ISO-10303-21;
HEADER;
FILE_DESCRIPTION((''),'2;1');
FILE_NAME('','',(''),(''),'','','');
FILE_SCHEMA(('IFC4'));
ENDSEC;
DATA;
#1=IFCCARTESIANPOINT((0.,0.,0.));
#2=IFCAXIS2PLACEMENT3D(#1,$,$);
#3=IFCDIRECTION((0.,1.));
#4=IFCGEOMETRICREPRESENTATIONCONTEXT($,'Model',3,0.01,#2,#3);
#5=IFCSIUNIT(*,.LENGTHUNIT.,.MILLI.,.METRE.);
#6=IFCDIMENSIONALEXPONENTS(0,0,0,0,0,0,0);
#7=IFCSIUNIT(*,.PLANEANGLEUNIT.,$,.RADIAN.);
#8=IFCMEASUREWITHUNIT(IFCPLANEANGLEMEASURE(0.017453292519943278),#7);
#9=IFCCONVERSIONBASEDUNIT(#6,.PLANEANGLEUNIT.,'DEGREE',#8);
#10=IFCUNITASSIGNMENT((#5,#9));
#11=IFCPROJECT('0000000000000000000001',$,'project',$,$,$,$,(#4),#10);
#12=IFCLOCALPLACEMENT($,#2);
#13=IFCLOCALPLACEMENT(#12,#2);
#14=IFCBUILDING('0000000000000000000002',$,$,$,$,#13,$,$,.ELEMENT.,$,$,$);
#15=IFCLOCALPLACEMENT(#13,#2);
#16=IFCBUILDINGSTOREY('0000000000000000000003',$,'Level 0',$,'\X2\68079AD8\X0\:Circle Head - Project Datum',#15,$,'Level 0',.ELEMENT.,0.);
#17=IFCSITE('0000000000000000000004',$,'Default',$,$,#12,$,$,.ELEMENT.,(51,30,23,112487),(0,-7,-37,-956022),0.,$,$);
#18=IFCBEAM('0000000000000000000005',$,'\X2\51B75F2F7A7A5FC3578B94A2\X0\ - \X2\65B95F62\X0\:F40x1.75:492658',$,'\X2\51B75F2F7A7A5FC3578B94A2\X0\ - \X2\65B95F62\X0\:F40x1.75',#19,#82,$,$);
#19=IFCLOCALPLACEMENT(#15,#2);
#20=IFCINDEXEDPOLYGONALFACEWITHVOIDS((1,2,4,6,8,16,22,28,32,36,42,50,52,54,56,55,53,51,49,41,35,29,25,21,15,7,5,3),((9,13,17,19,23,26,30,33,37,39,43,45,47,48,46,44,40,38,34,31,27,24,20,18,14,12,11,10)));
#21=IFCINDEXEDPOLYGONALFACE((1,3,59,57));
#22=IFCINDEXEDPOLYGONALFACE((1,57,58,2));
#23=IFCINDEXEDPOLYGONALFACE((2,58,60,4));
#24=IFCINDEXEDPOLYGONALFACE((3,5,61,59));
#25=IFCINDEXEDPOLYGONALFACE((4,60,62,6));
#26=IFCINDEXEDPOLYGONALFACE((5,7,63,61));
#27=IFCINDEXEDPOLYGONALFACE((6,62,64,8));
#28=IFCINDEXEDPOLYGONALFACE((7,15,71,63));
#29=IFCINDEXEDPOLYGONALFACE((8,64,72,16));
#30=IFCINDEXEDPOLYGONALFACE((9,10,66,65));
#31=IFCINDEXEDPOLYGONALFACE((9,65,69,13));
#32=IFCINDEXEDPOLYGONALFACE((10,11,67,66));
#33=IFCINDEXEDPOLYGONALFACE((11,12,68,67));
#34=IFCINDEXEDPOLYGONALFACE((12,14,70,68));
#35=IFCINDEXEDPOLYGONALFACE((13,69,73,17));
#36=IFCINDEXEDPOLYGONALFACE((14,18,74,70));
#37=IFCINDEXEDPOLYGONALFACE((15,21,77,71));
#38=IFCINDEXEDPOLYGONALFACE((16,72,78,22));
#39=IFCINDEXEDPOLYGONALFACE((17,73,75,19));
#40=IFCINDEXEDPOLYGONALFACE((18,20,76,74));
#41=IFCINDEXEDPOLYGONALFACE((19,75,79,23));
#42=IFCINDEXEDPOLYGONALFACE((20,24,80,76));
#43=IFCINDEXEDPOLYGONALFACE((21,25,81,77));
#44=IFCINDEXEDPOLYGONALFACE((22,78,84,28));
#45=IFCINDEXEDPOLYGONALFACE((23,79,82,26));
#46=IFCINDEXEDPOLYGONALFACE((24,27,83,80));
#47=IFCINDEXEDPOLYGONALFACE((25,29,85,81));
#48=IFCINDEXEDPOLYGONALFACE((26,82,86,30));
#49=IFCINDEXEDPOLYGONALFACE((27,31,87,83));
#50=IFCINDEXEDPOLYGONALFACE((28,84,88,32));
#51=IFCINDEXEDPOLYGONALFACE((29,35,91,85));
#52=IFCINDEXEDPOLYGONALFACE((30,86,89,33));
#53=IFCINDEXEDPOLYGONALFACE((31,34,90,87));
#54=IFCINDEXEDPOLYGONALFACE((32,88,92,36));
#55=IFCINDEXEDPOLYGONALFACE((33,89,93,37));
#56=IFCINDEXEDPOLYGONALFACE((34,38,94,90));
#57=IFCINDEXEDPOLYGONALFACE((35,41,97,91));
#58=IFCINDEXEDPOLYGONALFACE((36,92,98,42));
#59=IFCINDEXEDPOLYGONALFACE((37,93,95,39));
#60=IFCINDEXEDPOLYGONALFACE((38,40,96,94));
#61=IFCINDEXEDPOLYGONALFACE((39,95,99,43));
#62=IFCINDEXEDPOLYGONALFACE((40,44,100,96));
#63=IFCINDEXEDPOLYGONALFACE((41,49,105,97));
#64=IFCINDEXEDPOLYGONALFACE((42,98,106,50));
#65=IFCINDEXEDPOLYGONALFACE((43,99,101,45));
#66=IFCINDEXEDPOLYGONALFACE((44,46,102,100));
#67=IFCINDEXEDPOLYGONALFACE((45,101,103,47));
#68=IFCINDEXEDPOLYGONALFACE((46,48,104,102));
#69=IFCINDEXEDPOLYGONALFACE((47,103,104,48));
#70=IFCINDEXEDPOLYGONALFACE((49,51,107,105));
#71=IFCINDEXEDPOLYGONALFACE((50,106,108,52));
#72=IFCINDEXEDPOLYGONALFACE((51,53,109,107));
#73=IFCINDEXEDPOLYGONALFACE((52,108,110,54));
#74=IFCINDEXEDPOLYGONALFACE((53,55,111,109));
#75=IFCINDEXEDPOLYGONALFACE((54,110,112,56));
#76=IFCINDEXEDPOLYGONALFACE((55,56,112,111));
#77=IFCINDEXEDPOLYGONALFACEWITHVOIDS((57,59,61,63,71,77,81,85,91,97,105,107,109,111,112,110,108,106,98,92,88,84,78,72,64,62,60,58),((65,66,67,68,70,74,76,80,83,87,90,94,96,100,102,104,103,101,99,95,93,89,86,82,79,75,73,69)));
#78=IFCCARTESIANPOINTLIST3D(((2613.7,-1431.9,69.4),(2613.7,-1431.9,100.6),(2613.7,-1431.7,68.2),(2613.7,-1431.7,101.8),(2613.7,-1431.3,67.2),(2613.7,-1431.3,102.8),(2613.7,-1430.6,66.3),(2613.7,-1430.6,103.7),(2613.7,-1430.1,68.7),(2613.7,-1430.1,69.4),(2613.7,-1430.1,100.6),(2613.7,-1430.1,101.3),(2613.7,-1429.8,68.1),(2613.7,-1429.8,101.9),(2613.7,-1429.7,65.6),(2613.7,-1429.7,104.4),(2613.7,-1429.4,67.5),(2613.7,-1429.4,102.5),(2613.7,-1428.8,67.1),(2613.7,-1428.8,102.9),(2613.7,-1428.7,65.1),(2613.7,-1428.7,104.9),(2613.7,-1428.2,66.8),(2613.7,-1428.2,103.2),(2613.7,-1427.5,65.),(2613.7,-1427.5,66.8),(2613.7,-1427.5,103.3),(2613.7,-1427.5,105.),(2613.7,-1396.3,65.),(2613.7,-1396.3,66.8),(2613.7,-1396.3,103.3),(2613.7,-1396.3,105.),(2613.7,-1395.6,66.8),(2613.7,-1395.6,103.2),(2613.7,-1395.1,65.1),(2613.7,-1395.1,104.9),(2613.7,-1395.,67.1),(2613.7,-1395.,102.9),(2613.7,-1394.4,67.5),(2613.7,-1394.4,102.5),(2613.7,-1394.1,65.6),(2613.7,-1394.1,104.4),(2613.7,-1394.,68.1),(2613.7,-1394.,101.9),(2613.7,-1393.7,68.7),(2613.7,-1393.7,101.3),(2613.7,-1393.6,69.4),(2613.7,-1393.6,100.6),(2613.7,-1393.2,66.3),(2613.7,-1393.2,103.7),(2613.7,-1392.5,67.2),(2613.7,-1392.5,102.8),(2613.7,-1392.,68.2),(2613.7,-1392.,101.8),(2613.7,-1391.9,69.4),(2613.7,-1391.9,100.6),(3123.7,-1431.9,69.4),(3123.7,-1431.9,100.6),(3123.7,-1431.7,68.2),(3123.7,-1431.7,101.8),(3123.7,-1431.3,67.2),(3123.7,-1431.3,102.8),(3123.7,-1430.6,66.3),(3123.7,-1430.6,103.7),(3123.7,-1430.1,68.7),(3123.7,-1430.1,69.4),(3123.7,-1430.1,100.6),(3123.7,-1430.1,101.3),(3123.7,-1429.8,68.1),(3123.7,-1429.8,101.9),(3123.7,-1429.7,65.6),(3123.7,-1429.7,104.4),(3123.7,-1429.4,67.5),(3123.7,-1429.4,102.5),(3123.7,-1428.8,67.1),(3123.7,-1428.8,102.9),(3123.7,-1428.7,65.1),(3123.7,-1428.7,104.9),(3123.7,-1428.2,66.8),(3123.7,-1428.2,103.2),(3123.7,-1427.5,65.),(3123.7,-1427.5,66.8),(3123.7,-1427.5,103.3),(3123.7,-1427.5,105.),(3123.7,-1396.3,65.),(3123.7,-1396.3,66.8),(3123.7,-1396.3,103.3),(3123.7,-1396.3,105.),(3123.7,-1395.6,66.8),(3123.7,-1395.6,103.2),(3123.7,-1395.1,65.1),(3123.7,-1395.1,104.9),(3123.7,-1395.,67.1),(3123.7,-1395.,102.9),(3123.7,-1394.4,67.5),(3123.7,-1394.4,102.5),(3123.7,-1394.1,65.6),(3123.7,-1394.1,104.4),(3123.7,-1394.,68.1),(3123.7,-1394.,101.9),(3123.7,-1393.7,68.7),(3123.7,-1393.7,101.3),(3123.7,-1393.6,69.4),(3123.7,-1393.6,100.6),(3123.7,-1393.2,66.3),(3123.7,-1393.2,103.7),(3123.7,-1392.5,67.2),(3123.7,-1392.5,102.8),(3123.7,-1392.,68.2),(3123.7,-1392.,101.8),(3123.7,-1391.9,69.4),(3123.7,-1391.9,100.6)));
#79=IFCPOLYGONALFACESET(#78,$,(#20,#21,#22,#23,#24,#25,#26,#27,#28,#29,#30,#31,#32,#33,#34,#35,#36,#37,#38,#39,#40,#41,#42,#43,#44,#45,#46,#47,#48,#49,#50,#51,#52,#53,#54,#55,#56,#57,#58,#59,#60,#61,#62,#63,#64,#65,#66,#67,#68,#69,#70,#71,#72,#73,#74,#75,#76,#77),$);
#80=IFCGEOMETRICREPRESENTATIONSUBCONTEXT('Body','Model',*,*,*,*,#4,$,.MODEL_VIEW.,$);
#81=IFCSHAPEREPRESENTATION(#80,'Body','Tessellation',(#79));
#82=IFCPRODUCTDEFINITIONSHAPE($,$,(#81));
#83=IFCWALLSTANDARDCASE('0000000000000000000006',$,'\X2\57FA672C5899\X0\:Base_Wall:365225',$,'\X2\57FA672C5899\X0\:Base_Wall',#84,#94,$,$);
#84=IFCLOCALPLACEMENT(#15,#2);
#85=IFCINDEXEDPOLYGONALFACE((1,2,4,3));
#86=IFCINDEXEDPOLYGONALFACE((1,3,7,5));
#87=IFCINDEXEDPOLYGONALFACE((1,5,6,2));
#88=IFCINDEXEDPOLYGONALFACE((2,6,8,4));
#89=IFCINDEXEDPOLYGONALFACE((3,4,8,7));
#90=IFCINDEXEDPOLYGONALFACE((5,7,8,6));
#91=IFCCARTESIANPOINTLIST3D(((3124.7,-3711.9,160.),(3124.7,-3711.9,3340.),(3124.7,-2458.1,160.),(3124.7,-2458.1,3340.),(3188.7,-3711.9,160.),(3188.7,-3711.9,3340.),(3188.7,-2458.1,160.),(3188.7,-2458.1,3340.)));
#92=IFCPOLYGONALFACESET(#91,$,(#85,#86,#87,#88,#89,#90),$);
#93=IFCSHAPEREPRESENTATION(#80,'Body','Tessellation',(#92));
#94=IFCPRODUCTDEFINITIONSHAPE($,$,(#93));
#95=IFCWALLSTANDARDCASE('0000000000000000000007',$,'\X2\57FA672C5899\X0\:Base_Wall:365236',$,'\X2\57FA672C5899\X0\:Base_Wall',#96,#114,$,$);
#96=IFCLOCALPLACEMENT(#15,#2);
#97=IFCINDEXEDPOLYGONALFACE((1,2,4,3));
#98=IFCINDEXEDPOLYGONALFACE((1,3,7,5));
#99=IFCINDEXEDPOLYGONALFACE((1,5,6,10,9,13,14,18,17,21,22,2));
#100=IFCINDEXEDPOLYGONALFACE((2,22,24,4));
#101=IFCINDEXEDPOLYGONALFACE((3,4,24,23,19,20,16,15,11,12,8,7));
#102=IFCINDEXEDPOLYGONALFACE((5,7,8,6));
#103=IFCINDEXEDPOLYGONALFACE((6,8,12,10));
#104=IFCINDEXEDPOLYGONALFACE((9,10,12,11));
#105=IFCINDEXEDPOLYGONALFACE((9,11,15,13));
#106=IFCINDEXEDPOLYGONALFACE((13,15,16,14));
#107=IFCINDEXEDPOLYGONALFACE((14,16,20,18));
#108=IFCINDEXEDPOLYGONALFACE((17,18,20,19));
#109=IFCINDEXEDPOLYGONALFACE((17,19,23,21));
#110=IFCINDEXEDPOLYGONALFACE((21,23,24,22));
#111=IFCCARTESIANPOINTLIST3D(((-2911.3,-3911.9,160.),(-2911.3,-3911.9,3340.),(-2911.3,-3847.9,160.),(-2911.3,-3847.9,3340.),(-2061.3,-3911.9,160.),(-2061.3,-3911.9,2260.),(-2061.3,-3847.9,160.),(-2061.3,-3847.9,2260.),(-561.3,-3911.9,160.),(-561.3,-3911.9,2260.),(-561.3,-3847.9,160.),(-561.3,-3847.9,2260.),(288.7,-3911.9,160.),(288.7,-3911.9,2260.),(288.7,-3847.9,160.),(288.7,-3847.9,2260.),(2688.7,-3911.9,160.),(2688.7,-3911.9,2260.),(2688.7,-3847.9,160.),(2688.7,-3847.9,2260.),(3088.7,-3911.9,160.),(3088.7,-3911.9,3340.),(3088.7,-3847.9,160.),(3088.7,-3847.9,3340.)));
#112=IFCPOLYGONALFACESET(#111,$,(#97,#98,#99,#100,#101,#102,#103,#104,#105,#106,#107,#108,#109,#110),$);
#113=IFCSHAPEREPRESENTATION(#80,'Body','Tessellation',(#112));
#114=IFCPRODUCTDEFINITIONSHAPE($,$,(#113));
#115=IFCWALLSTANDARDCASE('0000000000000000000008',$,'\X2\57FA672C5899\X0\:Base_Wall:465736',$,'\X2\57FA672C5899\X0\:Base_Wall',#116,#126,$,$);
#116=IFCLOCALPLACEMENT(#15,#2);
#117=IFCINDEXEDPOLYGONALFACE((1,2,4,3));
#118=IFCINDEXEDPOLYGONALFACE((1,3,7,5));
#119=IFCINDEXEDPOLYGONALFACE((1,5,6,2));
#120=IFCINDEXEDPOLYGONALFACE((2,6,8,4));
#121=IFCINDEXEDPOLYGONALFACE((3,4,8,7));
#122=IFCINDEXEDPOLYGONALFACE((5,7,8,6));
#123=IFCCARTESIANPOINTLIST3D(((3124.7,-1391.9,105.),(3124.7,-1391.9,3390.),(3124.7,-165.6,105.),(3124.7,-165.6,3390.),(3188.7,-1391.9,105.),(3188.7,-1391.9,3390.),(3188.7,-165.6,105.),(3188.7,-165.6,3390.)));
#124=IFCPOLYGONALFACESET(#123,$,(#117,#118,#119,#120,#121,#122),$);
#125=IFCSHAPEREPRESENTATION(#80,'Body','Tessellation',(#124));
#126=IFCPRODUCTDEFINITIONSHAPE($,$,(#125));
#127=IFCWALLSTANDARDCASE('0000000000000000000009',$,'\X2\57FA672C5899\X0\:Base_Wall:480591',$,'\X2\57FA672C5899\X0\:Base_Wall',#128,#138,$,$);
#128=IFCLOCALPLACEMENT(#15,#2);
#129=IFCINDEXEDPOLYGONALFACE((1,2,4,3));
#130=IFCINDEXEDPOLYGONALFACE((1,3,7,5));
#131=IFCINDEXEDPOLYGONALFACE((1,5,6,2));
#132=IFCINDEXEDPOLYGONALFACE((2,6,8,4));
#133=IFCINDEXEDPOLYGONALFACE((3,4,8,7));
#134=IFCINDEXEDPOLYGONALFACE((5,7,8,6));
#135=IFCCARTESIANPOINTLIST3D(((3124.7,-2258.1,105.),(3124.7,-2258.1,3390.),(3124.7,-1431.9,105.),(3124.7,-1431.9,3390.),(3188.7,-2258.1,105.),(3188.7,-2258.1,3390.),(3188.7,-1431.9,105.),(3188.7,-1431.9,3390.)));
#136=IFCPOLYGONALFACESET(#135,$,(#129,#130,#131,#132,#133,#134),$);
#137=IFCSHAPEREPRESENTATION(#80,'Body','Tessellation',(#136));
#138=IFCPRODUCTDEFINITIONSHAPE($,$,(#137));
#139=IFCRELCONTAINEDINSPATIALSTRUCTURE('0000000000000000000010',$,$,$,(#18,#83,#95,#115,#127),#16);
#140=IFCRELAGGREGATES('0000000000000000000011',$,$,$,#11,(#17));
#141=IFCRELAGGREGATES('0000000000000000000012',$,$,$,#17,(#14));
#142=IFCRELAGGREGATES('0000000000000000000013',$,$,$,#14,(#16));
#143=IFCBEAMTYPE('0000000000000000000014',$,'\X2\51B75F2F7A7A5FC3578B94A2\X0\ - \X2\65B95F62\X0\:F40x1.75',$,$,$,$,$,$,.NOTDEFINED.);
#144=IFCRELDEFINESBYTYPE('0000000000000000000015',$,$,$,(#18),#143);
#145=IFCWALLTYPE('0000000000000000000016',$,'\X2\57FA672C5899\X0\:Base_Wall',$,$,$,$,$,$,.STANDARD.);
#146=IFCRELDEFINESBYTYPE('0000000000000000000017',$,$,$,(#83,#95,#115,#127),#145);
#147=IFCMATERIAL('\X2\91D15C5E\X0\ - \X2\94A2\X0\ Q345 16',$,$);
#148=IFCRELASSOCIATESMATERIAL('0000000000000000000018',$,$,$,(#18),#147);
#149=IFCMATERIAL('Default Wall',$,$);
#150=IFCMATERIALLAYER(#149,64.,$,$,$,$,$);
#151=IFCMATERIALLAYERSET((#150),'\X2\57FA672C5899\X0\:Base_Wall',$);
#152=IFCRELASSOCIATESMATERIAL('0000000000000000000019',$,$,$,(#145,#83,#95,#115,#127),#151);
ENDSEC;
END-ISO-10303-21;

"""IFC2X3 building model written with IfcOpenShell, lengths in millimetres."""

from ifc_helpers import new_model, entity, si_unit, converted_unit, direction, frame, frame_2d, origin, place, context, subcontext, project, spatial, polyline, circle_curve, parameter, trimmed, segment, composite_curve, rectangle, outline, extrude, material, layer, layer_set, layer_usage, type_object, element, save


model = new_model("IFC2X3")

# Units and contexts
model_context = context("Model", 3, precision=0.01, world=origin(), true_north=direction((0.0, 1.0)))
body_context = subcontext(model_context, "Body", "Model", "MODEL_VIEW")
ifc_project = project(units=[si_unit("LENGTHUNIT", "METRE", prefix="MILLI"), converted_unit("PLANEANGLEUNIT", "DEGREE", entity("IfcPlaneAngleMeasure", 0.017453292519943278), si_unit("PLANEANGLEUNIT", "RADIAN"), dimensions=[0, 0, 0, 0, 0, 0, 0])], contexts=[model_context])

# Site, building, storey
site_placement = place(None, origin())
site = spatial("IfcSite", under=ifc_project, at=site_placement, Name="Default", CompositionType="ELEMENT", RefLatitude=(51, 30, 23, 112487), RefLongitude=(0, -7, -37, -956022), RefElevation=0.0)
building_placement = place(site_placement, origin())
building = spatial("IfcBuilding", under=site, at=building_placement, CompositionType="ELEMENT")
storey_placement = place(building_placement, origin())
storey = spatial("IfcBuildingStorey", under=building, at=storey_placement, Name="Level 0", ObjectType="标高:Circle Head - Project Datum", LongName="Level 0", CompositionType="ELEMENT", Elevation=0.0)

# Beam
ifc_material_1 = material(Name="金属 - 钢 Q345 16")
beam_type_1 = type_object("IfcBeamType", Name="冷弯空心型钢 - 方形:F40x1.75", PredefinedType="NOTDEFINED")
beam_1_placement = place(storey_placement, frame((2613.7, -1411.9, 105.0)))
element("IfcBeam", 1, at=beam_1_placement, inside=storey, type_object=beam_type_1, material=ifc_material_1, Name="冷弯空心型钢 - 方形:F40x1.75:492658", ObjectType="冷弯空心型钢 - 方形:F40x1.75", context=body_context, shape_type="SweptSolid", body=[
    extrude(outline(composite_curve([segment(trimmed(circle_curve(frame_2d((-15.6, 15.6), x_axis=(1.0, 0.0)), 4.4), [parameter(90.0)], [parameter(180.0)], True, "PARAMETER"), True, "CONTINUOUS"), segment(polyline([(-20.0, 15.6), (-20.0, -15.6)]), True, "CONTINUOUS"), segment(trimmed(circle_curve(frame_2d((-15.6, -15.6), x_axis=(1.0, 0.0)), 4.4), [parameter(180.0)], [parameter(270.0)], True, "PARAMETER"), True, "CONTINUOUS"), segment(polyline([(-15.6, -20.0), (15.6, -20.0)]), True, "CONTINUOUS"), segment(trimmed(circle_curve(frame_2d((15.6, -15.6), x_axis=(1.0, 0.0)), 4.4), [parameter(270.0)], [parameter(0.0)], True, "PARAMETER"), True, "CONTINUOUS"), segment(polyline([(20.0, -15.6), (20.0, 15.6)]), True, "CONTINUOUS"), segment(trimmed(circle_curve(frame_2d((15.6, 15.6), x_axis=(1.0, 0.0)), 4.4), [parameter(0.0)], [parameter(90.0)], True, "PARAMETER"), True, "CONTINUOUS"), segment(polyline([(15.6, 20.0), (-15.6, 20.0)]), True, "CONTINUOUS")], self_intersect=False), holes=[composite_curve([segment(polyline([(-15.6, 18.3), (15.6, 18.3)]), True, "CONTINUOUS"), segment(trimmed(circle_curve(frame_2d((15.6, 15.6), x_axis=(1.0, 0.0)), 2.6), [parameter(0.0)], [parameter(90.0)], True, "PARAMETER"), False, "CONTINUOUS"), segment(polyline([(18.2, 15.6), (18.2, -15.6)]), True, "CONTINUOUS"), segment(trimmed(circle_curve(frame_2d((15.6, -15.6), x_axis=(1.0, 0.0)), 2.6), [parameter(270.0)], [parameter(360.0)], True, "PARAMETER"), False, "CONTINUOUS"), segment(polyline([(15.6, -18.2), (-15.6, -18.2)]), True, "CONTINUOUS"), segment(trimmed(circle_curve(frame_2d((-15.6, -15.6), x_axis=(1.0, 0.0)), 2.6), [parameter(180.0)], [parameter(270.0)], True, "PARAMETER"), False, "CONTINUOUS"), segment(polyline([(-18.3, -15.6), (-18.3, 15.6)]), True, "CONTINUOUS"), segment(trimmed(circle_curve(frame_2d((-15.6, 15.6), x_axis=(1.0, 0.0)), 2.6), [parameter(90.0)], [parameter(180.0)], True, "PARAMETER"), False, "CONTINUOUS")], self_intersect=False)]), frame((0.0, 0.0, -20.0), z_axis=(1.0, 0.0, 0.0), x_axis=(0.0, 1.0, 0.0)), (0.0, 0.0, 1.0), 510.0),
])

# Wall
ifc_material_2 = material(Name="Default Wall")
ifc_layer = layer(ifc_material_2, 64.0)
ifc_layer_set = layer_set([ifc_layer], Name="基本墙:Base_Wall")
ifc_layer_usage_1 = layer_usage(ifc_layer_set, "AXIS2", "NEGATIVE", 32.0)
wall_type = type_object("IfcWallType", Name="基本墙:Base_Wall", PredefinedType="STANDARD", material=ifc_layer_set)
wall_1_placement = place(storey_placement, frame((3156.7, -3711.9, 160.0), z_axis=(0.0, 0.0, 1.0), x_axis=(0.0, 1.0, 0.0)))
element("IfcWallStandardCase", 2, at=wall_1_placement, inside=storey, type_object=wall_type, material=ifc_layer_usage_1, Name="基本墙:Base_Wall:365225", ObjectType="基本墙:Base_Wall", context=body_context, shape_type="SweptSolid", body=[
    extrude(rectangle(XDim=1253.8, YDim=64.0, at=frame_2d((626.9, 0.0), x_axis=(-1.0, 0.0))), origin(), (0.0, 0.0, 1.0), 3180.0),
])

# Wall, openings
ifc_layer_usage_2 = layer_usage(ifc_layer_set, "AXIS2", "POSITIVE", -32.0)
wall_2_placement = place(storey_placement, frame((3088.7, -3879.9, 160.0), z_axis=(0.0, 0.0, 1.0), x_axis=(-1.0, 0.0, 0.0)))
wall_2 = element("IfcWallStandardCase", 3, at=wall_2_placement, inside=storey, type_object=wall_type, material=ifc_layer_usage_2, Name="基本墙:Base_Wall:365236", ObjectType="基本墙:Base_Wall", context=body_context, shape_type="SweptSolid", body=[
    extrude(rectangle(XDim=6000.0, YDim=64.0, at=frame_2d((3000.0, 0.0), x_axis=(1.0, 0.0))), origin(), (0.0, 0.0, 1.0), 3180.0),
])
opening_1_placement = place(wall_2_placement, frame((2800.0, 32.0, 0.0)))
element("IfcOpeningElement", 4, at=opening_1_placement, cuts=wall_2, ObjectType="Opening", context=body_context, shape_type="SweptSolid", body=[
    extrude(rectangle(XDim=2100.0, YDim=2400.0, at=frame_2d((1050.0, 1200.0), x_axis=(1.0, 0.0))), frame((0.0, 0.0, 0.0), z_axis=(0.0, -1.0, 0.0), x_axis=(0.0, 0.0, 1.0)), (0.0, 0.0, 1.0), 64.0),
])
opening_2_placement = place(wall_2_placement, frame((5150.0, 32.0, 0.0)))
element("IfcOpeningElement", 5, at=opening_2_placement, cuts=wall_2, ObjectType="Opening", context=body_context, shape_type="SweptSolid", body=[
    extrude(rectangle(XDim=2100.0, YDim=1500.0, at=frame_2d((1050.0, 750.0), x_axis=(1.0, 0.0))), frame((0.0, 0.0, 0.0), z_axis=(0.0, -1.0, 0.0), x_axis=(0.0, 0.0, 1.0)), (0.0, 0.0, 1.0), 64.0),
])

# Walls
ifc_layer_usage_3 = layer_usage(ifc_layer_set, "AXIS2", "NEGATIVE", 32.0)
wall_3_placement = place(storey_placement, frame((3156.7, -1391.9, 105.0), z_axis=(0.0, 0.0, 1.0), x_axis=(0.0, 1.0, 0.0)))
element("IfcWallStandardCase", 6, at=wall_3_placement, inside=storey, type_object=wall_type, material=ifc_layer_usage_3, Name="基本墙:Base_Wall:465736", ObjectType="基本墙:Base_Wall", context=body_context, shape_type="SweptSolid", body=[
    extrude(rectangle(XDim=1226.3, YDim=64.0, at=frame_2d((613.2, 0.0), x_axis=(-1.0, 0.0))), origin(), (0.0, 0.0, 1.0), 3285.0),
])
ifc_layer_usage_4 = layer_usage(ifc_layer_set, "AXIS2", "NEGATIVE", 32.0)
wall_4_placement = place(storey_placement, frame((3156.7, -2258.1, 105.0), z_axis=(0.0, 0.0, 1.0), x_axis=(0.0, 1.0, 0.0)))
element("IfcWallStandardCase", 7, at=wall_4_placement, inside=storey, type_object=wall_type, material=ifc_layer_usage_4, Name="基本墙:Base_Wall:480591", ObjectType="基本墙:Base_Wall", context=body_context, shape_type="SweptSolid", body=[
    extrude(rectangle(XDim=826.2, YDim=64.0, at=frame_2d((413.1, 0.0), x_axis=(-1.0, 0.0))), origin(), (0.0, 0.0, 1.0), 3285.0),
])

save(model, "model.ifc")
